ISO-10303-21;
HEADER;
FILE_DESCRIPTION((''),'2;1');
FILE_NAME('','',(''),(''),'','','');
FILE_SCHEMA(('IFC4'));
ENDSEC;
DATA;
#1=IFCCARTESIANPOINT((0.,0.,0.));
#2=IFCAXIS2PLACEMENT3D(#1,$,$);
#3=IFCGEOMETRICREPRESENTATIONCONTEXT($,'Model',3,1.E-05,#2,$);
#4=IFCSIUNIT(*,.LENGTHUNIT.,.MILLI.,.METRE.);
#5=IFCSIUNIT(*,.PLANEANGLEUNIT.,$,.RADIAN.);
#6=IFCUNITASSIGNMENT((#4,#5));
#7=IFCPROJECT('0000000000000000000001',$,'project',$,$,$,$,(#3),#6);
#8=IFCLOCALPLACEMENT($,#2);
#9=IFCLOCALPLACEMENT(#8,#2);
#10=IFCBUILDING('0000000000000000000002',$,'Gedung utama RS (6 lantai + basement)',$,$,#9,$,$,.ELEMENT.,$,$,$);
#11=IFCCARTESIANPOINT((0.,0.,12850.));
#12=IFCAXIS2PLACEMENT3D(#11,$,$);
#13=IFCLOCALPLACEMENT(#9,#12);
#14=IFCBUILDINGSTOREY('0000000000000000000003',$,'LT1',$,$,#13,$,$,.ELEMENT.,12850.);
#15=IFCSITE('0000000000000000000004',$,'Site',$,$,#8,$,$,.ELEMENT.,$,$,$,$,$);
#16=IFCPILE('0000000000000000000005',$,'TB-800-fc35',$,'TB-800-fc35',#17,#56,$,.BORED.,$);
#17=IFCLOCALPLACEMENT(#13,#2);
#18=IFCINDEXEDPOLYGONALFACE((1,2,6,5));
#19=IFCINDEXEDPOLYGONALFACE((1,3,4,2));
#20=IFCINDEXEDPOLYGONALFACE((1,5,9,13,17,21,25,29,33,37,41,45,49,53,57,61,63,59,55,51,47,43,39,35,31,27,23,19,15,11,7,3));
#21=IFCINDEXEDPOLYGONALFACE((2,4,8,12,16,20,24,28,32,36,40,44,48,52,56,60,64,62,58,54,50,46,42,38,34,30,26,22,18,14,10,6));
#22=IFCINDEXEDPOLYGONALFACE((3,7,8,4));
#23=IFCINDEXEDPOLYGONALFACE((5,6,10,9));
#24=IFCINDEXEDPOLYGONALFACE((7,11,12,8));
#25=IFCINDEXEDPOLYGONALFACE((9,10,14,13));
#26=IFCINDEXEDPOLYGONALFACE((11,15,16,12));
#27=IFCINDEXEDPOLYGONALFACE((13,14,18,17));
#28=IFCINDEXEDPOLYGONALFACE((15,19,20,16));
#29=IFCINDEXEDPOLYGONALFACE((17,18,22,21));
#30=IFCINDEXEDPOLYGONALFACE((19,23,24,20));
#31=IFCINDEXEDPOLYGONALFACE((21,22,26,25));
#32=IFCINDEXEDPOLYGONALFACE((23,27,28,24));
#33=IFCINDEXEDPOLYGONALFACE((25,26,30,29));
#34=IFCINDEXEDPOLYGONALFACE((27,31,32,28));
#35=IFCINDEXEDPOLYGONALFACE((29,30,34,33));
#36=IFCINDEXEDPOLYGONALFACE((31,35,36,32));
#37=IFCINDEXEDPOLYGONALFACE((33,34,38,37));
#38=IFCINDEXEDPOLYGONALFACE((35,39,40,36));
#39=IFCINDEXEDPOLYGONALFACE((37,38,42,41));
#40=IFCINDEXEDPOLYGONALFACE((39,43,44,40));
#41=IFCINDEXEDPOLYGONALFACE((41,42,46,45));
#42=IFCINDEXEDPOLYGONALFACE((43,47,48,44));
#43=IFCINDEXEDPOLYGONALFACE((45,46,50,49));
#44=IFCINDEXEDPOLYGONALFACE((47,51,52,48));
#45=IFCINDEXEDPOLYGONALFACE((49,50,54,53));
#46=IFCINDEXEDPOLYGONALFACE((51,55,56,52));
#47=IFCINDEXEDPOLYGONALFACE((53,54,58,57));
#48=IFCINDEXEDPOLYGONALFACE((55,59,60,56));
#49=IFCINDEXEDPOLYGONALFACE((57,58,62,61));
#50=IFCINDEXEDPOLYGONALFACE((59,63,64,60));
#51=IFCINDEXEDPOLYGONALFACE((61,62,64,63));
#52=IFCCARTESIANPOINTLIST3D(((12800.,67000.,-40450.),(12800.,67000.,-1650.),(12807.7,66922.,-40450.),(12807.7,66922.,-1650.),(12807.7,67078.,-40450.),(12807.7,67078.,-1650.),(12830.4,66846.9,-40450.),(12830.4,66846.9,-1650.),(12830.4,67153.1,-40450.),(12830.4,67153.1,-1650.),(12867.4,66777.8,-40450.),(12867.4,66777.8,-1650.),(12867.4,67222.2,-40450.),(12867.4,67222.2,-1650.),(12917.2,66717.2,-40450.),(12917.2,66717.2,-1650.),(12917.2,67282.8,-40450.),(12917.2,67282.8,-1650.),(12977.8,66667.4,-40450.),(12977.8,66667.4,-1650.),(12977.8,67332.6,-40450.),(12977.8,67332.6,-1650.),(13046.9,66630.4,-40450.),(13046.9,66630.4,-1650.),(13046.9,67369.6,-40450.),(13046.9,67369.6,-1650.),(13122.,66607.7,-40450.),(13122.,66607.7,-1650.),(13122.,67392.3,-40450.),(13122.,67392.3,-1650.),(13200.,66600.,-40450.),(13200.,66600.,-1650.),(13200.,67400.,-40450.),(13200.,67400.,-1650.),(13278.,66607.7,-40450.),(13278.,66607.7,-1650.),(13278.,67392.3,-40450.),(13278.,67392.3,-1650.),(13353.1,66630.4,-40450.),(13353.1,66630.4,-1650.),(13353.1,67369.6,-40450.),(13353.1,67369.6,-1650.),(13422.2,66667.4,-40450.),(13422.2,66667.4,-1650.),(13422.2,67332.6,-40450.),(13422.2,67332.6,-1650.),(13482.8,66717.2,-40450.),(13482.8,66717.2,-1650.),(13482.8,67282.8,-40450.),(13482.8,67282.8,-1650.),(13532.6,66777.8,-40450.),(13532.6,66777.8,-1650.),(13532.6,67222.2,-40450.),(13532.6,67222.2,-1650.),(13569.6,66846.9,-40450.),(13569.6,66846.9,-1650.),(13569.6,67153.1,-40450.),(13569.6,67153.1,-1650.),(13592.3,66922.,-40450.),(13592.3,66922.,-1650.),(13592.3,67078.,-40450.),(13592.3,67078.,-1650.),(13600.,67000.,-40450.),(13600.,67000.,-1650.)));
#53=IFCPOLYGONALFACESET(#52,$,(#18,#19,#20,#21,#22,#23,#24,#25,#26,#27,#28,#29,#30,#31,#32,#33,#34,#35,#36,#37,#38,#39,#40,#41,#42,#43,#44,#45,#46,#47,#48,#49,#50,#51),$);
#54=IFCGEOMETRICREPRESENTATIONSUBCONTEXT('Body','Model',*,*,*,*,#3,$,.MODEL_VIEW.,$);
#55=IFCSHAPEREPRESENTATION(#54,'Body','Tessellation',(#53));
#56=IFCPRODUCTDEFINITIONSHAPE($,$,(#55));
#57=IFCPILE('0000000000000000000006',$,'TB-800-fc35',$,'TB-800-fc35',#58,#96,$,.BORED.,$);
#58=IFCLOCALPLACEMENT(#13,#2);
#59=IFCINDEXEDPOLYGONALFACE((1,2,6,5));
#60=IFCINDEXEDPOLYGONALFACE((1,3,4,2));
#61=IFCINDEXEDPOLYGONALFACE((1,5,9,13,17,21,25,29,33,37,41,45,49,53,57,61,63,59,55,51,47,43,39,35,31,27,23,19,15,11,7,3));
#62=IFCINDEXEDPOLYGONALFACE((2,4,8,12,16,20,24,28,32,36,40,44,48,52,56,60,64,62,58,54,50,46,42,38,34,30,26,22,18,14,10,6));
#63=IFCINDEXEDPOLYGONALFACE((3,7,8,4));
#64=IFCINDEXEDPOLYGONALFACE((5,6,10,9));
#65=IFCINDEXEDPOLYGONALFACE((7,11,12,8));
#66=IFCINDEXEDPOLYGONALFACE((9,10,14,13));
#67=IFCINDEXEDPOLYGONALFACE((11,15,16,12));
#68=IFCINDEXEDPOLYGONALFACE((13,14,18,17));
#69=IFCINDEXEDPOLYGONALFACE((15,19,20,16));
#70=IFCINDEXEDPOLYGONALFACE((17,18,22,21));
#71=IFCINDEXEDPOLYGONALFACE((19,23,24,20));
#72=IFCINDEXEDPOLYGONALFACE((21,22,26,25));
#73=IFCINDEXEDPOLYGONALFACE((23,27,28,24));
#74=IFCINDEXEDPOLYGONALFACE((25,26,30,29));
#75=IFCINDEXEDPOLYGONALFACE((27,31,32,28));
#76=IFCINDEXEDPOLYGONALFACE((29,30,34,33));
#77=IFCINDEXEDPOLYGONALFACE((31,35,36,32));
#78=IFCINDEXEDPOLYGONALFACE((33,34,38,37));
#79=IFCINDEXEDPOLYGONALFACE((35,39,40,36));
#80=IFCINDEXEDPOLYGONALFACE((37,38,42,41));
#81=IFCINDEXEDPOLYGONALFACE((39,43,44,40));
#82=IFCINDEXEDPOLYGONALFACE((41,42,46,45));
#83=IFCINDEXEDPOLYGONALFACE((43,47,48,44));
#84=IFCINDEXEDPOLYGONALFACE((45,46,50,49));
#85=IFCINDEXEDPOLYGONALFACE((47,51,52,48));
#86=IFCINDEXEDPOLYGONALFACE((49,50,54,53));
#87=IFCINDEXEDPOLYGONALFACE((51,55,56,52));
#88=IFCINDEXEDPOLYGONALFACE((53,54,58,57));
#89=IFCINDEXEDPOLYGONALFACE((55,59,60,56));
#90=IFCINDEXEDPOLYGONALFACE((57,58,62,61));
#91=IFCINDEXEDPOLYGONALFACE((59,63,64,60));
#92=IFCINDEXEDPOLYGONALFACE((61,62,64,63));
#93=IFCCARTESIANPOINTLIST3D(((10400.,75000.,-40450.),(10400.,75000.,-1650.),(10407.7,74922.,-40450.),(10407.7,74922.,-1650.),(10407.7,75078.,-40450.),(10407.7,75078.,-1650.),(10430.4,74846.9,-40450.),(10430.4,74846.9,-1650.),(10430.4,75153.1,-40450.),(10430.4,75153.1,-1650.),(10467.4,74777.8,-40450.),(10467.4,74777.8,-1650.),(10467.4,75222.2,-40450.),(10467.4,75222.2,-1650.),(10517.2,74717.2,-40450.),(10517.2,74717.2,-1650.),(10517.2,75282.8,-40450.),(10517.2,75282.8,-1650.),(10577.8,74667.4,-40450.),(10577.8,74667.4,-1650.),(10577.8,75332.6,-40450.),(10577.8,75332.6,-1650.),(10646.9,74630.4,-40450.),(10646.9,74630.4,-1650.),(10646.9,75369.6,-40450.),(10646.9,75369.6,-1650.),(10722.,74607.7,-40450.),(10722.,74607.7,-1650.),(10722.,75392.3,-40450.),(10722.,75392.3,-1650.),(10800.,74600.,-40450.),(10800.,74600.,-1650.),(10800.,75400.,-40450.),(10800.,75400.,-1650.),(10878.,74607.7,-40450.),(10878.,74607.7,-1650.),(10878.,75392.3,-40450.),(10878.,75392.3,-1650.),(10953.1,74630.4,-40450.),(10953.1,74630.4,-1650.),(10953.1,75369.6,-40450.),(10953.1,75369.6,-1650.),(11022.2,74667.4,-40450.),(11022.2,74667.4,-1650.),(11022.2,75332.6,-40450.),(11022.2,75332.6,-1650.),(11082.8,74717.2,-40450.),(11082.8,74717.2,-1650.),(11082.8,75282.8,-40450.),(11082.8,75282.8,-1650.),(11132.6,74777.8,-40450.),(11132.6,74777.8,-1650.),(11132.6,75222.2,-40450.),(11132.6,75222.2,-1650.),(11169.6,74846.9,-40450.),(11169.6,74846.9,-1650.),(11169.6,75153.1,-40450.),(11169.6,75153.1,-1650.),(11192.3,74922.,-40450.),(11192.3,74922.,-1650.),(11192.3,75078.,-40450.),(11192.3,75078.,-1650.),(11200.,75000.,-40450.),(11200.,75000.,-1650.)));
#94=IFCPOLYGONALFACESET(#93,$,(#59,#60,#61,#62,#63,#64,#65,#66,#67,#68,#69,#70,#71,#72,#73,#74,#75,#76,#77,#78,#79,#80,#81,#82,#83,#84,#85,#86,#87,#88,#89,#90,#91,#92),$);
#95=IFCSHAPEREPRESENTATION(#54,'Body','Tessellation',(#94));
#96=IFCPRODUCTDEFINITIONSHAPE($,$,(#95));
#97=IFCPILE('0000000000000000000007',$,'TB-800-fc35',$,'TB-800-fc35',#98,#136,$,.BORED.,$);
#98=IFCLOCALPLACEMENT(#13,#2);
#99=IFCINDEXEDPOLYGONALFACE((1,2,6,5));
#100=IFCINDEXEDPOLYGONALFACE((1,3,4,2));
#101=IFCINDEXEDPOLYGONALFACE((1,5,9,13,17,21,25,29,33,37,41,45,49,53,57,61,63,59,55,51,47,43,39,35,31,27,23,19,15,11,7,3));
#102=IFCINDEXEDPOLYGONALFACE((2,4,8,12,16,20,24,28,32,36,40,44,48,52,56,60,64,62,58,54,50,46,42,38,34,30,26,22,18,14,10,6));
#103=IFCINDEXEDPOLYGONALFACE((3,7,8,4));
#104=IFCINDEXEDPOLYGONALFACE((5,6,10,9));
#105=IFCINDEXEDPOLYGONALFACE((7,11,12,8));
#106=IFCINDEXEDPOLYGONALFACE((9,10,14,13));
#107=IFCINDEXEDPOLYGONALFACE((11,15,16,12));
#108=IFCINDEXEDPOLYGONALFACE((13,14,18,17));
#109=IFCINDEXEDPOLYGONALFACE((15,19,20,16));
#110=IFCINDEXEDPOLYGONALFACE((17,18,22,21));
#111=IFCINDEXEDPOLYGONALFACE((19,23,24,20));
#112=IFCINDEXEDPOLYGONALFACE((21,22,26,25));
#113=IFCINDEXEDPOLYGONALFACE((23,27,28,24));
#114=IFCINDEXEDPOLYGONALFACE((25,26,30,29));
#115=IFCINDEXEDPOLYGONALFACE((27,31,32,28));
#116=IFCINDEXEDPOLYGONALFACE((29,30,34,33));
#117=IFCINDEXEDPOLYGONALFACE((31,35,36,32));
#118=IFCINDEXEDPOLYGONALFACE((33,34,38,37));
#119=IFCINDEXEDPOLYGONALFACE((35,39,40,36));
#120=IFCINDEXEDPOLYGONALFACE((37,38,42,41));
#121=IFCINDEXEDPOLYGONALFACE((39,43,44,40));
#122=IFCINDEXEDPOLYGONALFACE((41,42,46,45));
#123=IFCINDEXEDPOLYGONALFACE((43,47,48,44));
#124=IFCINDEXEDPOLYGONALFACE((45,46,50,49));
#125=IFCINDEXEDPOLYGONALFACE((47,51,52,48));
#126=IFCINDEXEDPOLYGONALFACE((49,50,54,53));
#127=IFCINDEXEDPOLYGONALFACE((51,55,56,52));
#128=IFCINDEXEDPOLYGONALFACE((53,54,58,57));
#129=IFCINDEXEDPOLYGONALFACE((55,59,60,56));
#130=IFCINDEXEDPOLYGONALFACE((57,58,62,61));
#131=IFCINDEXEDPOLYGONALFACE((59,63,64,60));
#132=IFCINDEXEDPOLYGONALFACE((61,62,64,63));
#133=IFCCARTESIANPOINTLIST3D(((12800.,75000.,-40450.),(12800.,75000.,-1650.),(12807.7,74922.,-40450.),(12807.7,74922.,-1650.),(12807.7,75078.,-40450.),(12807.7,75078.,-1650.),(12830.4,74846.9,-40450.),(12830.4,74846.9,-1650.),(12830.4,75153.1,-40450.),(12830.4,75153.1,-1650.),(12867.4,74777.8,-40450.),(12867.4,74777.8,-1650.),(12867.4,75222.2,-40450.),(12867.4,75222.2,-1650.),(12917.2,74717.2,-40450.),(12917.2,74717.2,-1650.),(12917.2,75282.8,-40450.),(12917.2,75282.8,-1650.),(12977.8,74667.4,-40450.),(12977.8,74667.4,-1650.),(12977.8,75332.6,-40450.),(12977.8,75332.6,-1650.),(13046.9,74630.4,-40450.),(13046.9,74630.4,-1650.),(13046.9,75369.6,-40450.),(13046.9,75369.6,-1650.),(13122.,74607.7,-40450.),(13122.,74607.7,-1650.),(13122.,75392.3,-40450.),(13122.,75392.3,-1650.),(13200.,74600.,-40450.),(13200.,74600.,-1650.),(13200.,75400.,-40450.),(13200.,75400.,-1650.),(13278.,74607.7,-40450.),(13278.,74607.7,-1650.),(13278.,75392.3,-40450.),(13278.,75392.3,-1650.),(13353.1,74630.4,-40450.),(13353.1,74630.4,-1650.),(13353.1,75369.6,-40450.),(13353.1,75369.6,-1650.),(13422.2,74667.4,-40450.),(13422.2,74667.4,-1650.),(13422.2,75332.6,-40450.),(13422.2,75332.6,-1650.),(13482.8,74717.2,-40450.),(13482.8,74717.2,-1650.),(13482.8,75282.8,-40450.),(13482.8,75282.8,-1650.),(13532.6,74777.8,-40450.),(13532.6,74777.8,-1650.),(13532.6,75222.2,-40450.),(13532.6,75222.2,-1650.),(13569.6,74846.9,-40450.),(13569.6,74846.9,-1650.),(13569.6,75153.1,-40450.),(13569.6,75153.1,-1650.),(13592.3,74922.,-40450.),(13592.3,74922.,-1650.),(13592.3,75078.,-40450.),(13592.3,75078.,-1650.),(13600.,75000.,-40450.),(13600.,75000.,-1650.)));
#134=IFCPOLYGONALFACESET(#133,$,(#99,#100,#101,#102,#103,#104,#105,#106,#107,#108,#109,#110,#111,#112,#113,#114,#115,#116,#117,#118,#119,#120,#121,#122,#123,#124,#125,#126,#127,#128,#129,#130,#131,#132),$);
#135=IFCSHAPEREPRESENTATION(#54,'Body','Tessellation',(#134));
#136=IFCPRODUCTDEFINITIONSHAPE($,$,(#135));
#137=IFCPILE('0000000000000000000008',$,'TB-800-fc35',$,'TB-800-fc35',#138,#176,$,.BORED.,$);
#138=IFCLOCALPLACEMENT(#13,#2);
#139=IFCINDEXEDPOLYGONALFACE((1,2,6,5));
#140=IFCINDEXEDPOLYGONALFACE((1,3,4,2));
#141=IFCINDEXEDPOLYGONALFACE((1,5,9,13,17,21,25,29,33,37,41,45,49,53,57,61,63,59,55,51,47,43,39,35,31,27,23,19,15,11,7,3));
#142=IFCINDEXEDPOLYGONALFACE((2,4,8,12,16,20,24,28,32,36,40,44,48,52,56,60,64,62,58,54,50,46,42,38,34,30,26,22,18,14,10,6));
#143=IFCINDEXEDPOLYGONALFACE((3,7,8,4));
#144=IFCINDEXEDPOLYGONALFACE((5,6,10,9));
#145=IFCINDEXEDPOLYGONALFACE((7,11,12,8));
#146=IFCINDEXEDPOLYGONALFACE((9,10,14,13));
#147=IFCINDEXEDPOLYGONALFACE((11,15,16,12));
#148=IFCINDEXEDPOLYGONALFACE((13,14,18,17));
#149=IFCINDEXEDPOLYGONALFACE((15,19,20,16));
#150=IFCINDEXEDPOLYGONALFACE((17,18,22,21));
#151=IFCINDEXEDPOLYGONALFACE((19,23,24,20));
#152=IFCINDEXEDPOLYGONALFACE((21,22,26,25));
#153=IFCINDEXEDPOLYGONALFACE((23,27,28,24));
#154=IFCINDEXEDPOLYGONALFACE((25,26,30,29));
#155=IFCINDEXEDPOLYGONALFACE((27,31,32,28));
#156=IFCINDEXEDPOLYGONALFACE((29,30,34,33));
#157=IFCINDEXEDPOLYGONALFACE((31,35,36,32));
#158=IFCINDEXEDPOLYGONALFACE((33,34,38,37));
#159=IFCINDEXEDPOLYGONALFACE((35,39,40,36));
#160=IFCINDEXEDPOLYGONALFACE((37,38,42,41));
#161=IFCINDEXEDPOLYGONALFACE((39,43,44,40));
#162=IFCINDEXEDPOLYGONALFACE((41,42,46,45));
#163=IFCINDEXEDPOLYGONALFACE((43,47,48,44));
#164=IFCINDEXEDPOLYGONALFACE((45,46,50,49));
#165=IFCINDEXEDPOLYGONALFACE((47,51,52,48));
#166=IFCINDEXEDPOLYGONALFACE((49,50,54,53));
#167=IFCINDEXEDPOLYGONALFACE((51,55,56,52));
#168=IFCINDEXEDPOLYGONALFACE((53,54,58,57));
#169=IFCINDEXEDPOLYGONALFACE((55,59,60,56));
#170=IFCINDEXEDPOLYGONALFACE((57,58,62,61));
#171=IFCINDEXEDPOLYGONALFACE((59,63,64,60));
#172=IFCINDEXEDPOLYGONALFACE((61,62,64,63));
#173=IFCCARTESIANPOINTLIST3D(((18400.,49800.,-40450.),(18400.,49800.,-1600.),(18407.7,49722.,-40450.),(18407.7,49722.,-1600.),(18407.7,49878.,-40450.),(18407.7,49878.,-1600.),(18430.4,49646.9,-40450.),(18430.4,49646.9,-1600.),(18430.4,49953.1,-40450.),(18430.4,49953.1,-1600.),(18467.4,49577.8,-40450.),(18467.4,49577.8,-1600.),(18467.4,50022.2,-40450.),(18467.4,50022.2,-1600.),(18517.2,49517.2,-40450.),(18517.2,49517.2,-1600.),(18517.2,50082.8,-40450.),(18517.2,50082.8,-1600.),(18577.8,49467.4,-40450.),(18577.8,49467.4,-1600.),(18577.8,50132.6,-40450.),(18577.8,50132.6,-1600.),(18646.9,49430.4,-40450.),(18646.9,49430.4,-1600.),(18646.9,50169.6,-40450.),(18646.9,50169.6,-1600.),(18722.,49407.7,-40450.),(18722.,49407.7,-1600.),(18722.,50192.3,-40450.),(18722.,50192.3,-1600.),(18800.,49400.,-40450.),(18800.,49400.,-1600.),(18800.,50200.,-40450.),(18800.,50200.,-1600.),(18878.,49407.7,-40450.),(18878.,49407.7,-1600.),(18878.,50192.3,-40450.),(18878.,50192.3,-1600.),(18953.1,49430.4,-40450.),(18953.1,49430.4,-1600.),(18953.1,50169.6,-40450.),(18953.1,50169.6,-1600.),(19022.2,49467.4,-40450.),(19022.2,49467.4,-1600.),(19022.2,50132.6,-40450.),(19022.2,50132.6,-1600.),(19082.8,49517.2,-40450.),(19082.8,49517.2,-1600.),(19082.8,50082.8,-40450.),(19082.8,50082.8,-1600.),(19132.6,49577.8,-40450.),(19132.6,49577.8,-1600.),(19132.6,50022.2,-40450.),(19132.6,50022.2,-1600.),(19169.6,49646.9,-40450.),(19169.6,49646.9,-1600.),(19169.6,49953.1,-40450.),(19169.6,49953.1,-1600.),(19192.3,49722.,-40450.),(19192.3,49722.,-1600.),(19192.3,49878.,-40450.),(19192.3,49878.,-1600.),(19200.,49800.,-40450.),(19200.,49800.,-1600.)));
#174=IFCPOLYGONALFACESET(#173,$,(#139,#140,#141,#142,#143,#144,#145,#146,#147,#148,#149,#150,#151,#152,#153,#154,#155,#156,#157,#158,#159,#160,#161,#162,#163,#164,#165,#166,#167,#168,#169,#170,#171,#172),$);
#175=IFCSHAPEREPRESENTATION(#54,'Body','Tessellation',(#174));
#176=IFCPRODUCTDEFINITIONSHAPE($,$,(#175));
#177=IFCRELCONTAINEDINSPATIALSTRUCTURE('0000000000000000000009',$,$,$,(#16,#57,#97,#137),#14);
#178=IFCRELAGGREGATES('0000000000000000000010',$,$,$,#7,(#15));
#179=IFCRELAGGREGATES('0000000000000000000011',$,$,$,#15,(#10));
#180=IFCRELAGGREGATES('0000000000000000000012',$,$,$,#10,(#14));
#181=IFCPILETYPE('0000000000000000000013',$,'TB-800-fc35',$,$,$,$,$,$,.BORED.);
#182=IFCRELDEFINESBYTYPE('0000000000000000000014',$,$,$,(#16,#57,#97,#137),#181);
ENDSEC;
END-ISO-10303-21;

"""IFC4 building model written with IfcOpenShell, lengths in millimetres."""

from ifc_helpers import new_model, si_unit, frame, origin, origin_2d, place, context, subcontext, project, spatial, circle, extrude, material_profile, profile_set, profile_usage, type_object, element, save


model = new_model("IFC4")

# Units and contexts
model_context = context("Model", 3, precision=1e-05, world=origin())
body_context = subcontext(model_context, "Body", "Model", "MODEL_VIEW")
ifc_project = project(units=[si_unit("LENGTHUNIT", "METRE", prefix="MILLI"), si_unit("PLANEANGLEUNIT", "RADIAN")], contexts=[model_context])

# Site, building, storey
site_placement = place(None, origin())
site = spatial("IfcSite", under=ifc_project, at=site_placement, Name="Site", CompositionType="ELEMENT")
building_placement = place(site_placement, origin())
building = spatial("IfcBuilding", under=site, at=building_placement, Name="Gedung utama RS (6 lantai + basement)", CompositionType="ELEMENT")
storey_placement = place(building_placement, frame((0.0, 0.0, 12850.0)))
storey = spatial("IfcBuildingStorey", under=building, at=storey_placement, Name="LT1", CompositionType="ELEMENT", Elevation=12850.0)

# Piles
ifc_material_profile = material_profile(None, circle(Radius=400.0, at=origin_2d()), Name="TB-800-fc35")
ifc_profile_set = profile_set([ifc_material_profile], Name="TB-800-fc35")
ifc_profile_usage = profile_usage(ifc_profile_set, cardinal=5)
pile_type = type_object("IfcPileType", Name="TB-800-fc35", PredefinedType="BORED", material=ifc_profile_set)
for number, where, z_axis, x_axis, name in (
    (1, (13200.0, 67000.0, -40450.0), (0.0, 0.0, 1.0), (1.0, 0.0, 0.0), "TB-800-fc35"),
    (2, (10800.0, 75000.0, -40450.0), (0.0, 0.0, 1.0), (1.0, 0.0, 0.0), "TB-800-fc35"),
    (3, (13200.0, 75000.0, -40450.0), (0.0, 0.0, 1.0), (1.0, 0.0, 0.0), "TB-800-fc35"),
):
    element("IfcPile", number, at=place(storey_placement, frame(where, z_axis=z_axis, x_axis=x_axis)), inside=storey, type_object=pile_type, material=ifc_profile_usage, Name=name, ObjectType="TB-800-fc35", PredefinedType="BORED", context=body_context, shape_type="SweptSolid", body=[
        extrude(circle(Radius=400.0, at=origin_2d()), origin(), (0.0, 0.0, 1.0), 38800.0),
    ])
for number, where, z_axis, x_axis, name in (
    (4, (18800.0, 49800.0, -40450.0), (0.0, 0.0, 1.0), (1.0, 0.0, 0.0), "TB-800-fc35"),
):
    element("IfcPile", number, at=place(storey_placement, frame(where, z_axis=z_axis, x_axis=x_axis)), inside=storey, type_object=pile_type, material=ifc_profile_usage, Name=name, ObjectType="TB-800-fc35", PredefinedType="BORED", context=body_context, shape_type="SweptSolid", body=[
        extrude(circle(Radius=400.0, at=origin_2d()), origin(), (0.0, 0.0, 1.0), 38850.0),
    ])

save(model, "model.ifc")
